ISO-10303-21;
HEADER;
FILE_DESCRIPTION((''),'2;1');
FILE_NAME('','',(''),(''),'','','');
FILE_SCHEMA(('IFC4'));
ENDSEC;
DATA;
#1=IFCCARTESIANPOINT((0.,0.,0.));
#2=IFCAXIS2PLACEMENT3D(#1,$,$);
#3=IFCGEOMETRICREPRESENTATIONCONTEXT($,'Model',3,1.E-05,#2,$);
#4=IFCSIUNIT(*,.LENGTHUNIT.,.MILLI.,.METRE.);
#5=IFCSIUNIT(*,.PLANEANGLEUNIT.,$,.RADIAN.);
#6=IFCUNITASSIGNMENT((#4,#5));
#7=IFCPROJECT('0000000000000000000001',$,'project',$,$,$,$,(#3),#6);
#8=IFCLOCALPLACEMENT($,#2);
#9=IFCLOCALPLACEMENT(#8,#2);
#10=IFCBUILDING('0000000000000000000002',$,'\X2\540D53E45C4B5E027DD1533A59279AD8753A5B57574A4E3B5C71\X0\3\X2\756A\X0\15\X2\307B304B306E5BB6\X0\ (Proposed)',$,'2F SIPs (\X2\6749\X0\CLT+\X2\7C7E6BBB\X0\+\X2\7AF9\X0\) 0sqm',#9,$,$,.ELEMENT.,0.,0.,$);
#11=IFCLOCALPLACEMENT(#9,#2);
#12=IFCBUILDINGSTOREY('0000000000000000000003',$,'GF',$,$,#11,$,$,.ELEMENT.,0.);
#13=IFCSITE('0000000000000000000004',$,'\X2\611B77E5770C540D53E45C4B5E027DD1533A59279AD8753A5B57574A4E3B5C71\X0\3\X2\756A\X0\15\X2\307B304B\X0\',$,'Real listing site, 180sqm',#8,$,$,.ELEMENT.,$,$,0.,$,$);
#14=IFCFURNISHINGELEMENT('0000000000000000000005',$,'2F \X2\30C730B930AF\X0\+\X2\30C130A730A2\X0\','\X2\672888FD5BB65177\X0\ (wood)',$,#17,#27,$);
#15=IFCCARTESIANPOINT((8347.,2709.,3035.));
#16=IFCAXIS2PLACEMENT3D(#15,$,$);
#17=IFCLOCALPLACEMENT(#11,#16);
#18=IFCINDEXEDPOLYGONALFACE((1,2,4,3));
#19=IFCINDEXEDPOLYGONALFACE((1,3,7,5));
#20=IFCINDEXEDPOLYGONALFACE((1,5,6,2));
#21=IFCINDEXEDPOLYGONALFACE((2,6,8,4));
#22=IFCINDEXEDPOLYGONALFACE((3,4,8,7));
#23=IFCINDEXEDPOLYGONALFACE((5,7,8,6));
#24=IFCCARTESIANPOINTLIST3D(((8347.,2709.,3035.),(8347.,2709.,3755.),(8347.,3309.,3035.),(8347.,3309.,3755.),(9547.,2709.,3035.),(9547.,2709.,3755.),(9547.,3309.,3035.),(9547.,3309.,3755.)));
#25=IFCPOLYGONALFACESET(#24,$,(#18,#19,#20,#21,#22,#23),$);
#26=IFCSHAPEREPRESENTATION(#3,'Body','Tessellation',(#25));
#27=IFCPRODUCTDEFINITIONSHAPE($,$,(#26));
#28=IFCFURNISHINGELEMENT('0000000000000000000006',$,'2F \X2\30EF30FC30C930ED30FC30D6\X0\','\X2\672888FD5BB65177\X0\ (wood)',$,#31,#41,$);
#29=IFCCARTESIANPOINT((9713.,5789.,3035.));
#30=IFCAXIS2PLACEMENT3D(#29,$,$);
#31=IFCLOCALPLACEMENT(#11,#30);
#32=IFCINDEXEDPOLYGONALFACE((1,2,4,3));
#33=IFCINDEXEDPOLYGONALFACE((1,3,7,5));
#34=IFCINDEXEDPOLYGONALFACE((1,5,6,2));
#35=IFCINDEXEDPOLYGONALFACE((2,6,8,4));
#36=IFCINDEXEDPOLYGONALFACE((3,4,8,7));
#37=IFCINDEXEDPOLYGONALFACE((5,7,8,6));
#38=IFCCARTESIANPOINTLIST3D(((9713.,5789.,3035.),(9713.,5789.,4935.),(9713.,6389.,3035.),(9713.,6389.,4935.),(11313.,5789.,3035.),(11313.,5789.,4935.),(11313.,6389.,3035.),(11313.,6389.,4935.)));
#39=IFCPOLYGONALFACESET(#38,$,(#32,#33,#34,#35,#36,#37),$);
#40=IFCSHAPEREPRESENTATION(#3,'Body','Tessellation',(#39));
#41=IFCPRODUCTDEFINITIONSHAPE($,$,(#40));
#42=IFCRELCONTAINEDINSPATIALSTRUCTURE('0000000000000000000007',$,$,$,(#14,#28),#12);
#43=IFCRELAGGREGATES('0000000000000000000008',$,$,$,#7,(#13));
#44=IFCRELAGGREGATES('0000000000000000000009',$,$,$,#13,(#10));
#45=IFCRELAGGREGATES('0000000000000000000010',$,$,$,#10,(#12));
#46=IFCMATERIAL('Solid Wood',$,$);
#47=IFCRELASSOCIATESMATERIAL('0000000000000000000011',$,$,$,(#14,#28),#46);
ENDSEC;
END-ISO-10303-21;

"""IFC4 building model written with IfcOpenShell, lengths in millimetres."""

from ifc_helpers import new_model, si_unit, frame, frame_2d, origin, place, context, project, spatial, rectangle, extrude, material, element, save


model = new_model("IFC4")

# Units and contexts
model_context = context("Model", 3, precision=1e-05, world=origin())
ifc_project = project(units=[si_unit("LENGTHUNIT", "METRE", prefix="MILLI"), si_unit("PLANEANGLEUNIT", "RADIAN")], contexts=[model_context])

# Site, building, storey
site_placement = place(None, origin())
site = spatial("IfcSite", under=ifc_project, at=site_placement, Name="愛知県名古屋市緑区大高町字坊主山3番15ほか", ObjectType="Real listing site, 180sqm", CompositionType="ELEMENT", RefElevation=0.0)
building_placement = place(site_placement, origin())
building = spatial("IfcBuilding", under=site, at=building_placement, Name="名古屋市緑区大高町字坊主山3番15ほかの家 (Proposed)", ObjectType="2F SIPs (杉CLT+籾殻+竹) 0sqm", CompositionType="ELEMENT", ElevationOfRefHeight=0.0, ElevationOfTerrain=0.0)
storey_placement = place(building_placement, origin())
storey = spatial("IfcBuildingStorey", under=building, at=storey_placement, Name="GF", CompositionType="ELEMENT", Elevation=0.0)

# Shared definitions
ifc_material_1 = material(Name="Solid Wood")

# Furnishing elements
furnishing_1_placement = place(storey_placement, frame((8347.0, 2709.0, 3035.0)))
element("IfcFurnishingElement", 1, at=furnishing_1_placement, inside=storey, material=ifc_material_1, Name="2F デスク+チェア", Description="木製家具 (wood)", context=model_context, shape_type="SweptSolid", body=[
    extrude(rectangle(XDim=1200.0, YDim=600.0, at=frame_2d((600.0, 300.0))), frame((8347.0, 2709.0, 3035.0)), (0.0, 0.0, 1.0), 720.0),
])
furnishing_2_placement = place(storey_placement, frame((9713.0, 5789.0, 3035.0)))
element("IfcFurnishingElement", 2, at=furnishing_2_placement, inside=storey, material=ifc_material_1, Name="2F ワードローブ", Description="木製家具 (wood)", context=model_context, shape_type="SweptSolid", body=[
    extrude(rectangle(XDim=1600.0, YDim=600.0, at=frame_2d((800.0, 300.0))), frame((9713.0, 5789.0, 3035.0)), (0.0, 0.0, 1.0), 1900.0),
])

save(model, "model.ifc")
